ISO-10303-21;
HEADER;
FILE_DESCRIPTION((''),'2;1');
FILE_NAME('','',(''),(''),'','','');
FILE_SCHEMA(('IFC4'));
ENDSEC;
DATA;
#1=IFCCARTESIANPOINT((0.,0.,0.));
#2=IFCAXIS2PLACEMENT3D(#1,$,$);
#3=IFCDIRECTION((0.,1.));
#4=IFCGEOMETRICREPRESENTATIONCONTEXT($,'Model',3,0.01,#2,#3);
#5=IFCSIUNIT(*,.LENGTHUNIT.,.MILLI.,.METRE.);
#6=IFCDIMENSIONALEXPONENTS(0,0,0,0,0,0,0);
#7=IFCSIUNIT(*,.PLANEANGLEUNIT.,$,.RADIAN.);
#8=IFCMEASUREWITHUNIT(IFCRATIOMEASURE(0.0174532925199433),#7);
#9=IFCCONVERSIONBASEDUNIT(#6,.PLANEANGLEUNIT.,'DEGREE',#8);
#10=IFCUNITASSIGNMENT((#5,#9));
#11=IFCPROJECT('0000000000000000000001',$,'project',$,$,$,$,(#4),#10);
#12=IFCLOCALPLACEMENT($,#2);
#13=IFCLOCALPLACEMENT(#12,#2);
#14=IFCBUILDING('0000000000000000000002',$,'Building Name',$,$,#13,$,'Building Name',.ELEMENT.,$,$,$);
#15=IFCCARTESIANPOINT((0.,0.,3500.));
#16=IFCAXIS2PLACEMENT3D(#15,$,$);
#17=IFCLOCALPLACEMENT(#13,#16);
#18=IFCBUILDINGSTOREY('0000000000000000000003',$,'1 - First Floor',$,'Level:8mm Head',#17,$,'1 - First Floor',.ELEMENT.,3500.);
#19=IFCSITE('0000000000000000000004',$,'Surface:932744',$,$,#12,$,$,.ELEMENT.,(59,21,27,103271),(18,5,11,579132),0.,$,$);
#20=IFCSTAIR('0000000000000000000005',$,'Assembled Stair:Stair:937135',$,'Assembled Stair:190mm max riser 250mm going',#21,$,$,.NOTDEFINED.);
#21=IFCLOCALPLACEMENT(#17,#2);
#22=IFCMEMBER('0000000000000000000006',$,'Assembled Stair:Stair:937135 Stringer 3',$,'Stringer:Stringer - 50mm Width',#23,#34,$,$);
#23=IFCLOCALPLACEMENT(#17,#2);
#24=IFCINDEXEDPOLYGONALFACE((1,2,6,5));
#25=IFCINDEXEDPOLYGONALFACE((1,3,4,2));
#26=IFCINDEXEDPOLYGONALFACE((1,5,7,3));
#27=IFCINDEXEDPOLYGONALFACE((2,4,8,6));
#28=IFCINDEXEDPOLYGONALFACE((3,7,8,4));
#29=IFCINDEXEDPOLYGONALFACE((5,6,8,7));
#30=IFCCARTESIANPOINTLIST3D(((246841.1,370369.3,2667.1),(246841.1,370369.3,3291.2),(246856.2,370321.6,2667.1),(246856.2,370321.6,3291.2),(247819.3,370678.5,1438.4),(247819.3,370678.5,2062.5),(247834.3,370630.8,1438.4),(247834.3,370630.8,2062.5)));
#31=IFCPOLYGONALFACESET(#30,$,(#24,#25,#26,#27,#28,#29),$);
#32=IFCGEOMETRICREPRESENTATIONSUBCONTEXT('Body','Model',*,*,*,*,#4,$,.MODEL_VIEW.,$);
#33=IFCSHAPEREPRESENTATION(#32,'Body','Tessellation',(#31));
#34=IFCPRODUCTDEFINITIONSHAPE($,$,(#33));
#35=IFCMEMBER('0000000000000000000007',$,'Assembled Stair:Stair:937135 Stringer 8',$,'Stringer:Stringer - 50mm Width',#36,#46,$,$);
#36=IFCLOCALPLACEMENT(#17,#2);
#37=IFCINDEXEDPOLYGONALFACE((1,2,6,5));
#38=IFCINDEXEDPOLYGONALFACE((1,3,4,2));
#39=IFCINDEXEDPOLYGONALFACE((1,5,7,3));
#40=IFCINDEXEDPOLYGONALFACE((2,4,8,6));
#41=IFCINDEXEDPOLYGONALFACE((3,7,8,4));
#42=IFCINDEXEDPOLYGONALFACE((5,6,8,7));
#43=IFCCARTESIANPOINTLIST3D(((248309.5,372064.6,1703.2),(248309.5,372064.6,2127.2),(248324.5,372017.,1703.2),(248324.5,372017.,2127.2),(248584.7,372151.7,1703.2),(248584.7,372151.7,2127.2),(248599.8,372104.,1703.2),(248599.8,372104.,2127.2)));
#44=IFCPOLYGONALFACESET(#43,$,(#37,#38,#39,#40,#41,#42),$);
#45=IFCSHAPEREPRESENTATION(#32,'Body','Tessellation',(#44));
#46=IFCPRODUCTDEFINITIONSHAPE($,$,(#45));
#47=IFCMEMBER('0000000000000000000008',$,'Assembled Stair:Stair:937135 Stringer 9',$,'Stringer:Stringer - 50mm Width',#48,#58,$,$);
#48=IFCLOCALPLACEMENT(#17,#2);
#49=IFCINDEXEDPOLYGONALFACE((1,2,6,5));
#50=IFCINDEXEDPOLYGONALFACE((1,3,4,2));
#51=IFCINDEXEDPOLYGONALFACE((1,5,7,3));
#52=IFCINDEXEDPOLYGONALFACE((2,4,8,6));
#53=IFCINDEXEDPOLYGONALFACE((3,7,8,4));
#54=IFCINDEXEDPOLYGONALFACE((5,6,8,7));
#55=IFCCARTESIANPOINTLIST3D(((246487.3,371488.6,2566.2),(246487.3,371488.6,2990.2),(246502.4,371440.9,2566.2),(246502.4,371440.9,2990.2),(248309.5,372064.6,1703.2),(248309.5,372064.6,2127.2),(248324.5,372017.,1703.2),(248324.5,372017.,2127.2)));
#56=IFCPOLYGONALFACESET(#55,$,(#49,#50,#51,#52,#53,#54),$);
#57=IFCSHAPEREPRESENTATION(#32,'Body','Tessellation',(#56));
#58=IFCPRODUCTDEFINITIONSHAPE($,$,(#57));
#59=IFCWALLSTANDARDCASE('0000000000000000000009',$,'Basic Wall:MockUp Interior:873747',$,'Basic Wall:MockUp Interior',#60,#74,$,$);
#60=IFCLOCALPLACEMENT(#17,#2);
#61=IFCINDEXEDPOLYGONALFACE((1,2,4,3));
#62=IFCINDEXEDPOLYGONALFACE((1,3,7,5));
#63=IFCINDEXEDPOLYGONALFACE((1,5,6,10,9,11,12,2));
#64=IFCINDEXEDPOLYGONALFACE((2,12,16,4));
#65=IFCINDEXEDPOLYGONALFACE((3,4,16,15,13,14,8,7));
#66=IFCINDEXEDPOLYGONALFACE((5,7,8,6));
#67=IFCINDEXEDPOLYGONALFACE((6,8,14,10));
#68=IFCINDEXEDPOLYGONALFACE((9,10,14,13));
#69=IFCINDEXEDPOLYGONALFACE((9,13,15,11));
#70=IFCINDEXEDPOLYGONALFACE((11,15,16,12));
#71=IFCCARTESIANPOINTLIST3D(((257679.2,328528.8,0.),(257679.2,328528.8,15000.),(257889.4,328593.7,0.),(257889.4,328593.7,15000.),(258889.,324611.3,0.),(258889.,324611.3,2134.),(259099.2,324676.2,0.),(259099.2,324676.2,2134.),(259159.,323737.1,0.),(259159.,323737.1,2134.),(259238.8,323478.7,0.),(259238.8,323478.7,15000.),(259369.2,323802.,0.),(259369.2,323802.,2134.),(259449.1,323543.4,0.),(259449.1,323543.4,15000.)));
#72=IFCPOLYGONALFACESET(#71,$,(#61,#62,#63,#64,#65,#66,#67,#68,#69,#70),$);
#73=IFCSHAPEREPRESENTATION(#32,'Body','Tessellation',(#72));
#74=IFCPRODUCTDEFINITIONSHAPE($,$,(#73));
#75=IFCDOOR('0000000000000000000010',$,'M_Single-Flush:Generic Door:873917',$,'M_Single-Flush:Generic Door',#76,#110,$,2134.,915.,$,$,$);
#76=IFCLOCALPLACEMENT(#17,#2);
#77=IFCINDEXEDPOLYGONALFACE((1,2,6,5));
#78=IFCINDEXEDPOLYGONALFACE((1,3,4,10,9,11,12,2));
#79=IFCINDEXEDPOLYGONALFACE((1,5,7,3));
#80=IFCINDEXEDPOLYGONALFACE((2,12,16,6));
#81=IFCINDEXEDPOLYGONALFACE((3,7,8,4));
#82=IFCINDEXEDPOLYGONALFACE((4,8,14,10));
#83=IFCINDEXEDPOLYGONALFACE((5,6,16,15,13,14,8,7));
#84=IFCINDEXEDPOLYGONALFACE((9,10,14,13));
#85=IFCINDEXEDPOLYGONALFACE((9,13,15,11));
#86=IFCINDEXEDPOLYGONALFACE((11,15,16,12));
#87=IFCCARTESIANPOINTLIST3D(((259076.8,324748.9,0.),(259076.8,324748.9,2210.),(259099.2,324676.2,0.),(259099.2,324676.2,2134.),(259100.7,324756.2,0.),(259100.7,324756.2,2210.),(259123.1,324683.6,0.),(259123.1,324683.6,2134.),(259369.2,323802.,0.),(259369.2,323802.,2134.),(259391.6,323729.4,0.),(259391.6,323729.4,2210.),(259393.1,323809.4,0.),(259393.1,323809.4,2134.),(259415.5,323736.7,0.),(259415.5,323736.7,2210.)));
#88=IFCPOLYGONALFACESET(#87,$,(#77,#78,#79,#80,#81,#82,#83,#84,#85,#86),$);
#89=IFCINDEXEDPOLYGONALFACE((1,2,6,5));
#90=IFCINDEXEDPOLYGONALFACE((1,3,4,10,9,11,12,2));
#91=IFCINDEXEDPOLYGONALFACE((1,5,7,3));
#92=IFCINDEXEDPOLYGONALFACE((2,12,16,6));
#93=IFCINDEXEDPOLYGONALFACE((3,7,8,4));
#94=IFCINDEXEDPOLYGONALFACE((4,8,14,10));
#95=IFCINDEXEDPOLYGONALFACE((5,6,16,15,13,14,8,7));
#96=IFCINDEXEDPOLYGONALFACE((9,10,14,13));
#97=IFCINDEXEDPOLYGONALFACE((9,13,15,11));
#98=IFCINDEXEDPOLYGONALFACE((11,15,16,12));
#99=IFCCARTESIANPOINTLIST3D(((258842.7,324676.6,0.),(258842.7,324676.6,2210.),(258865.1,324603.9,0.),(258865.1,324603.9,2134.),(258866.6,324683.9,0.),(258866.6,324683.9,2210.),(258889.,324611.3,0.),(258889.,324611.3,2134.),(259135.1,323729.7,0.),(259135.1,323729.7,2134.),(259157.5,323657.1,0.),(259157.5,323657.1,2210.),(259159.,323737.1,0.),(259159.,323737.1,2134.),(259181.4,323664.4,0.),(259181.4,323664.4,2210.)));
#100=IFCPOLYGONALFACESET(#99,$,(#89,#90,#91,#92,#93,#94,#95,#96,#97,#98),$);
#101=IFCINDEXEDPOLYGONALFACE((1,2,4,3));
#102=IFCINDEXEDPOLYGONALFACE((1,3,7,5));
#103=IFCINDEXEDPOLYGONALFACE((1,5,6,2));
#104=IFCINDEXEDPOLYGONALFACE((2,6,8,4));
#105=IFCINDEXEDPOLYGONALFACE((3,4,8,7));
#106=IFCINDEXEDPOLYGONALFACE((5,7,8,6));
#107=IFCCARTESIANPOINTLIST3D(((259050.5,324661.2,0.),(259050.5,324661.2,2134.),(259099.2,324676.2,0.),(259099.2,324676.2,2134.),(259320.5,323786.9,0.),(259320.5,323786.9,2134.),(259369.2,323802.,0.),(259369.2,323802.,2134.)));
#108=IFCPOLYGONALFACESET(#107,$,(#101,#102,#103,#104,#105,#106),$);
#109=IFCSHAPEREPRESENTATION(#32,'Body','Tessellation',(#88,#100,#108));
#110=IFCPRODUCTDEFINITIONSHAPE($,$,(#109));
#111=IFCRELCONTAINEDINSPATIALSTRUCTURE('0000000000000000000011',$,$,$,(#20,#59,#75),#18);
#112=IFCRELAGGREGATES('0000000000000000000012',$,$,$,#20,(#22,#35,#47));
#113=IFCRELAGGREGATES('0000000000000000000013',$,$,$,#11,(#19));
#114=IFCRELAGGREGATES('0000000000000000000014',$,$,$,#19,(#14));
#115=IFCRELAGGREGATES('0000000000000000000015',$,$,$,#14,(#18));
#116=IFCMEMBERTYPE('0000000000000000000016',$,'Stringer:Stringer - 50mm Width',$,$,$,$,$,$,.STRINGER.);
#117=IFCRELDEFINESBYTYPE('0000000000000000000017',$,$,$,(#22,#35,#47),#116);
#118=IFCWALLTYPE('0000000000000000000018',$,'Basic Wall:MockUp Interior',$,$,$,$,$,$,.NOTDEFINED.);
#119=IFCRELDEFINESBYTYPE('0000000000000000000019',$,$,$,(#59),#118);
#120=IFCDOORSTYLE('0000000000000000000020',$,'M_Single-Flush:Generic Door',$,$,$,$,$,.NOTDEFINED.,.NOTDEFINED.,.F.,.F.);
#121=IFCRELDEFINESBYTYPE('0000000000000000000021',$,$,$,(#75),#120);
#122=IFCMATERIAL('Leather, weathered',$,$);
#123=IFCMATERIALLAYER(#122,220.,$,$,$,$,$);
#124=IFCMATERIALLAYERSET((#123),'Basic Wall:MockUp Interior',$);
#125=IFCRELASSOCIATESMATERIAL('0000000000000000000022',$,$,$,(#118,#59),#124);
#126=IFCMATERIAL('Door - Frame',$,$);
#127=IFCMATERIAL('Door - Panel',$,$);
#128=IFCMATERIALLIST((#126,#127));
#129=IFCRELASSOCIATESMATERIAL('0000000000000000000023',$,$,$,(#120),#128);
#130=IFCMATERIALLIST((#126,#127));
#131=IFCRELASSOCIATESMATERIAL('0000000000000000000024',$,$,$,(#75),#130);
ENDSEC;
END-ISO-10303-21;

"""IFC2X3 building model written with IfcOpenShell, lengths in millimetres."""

from ifc_helpers import new_model, entity, si_unit, converted_unit, direction, frame, frame_2d, origin, place, context, subcontext, project, spatial, polyline, rectangle, outline, extrude, source, transform, mapped, material, material_list, layer, layer_set, layer_usage, type_object, type_shapes, element, fill, aggregate, save


model = new_model("IFC2X3")

# Units and contexts
model_context = context("Model", 3, precision=0.01, world=origin(), true_north=direction((0.0, 1.0)))
body_context = subcontext(model_context, "Body", "Model", "MODEL_VIEW")
ifc_project = project(units=[si_unit("LENGTHUNIT", "METRE", prefix="MILLI"), converted_unit("PLANEANGLEUNIT", "DEGREE", entity("IfcRatioMeasure", 0.0174532925199433), si_unit("PLANEANGLEUNIT", "RADIAN"), dimensions=[0, 0, 0, 0, 0, 0, 0])], contexts=[model_context])

# Site, building, storey
site_placement = place(None, origin())
site = spatial("IfcSite", under=ifc_project, at=site_placement, Name="Surface:932744", CompositionType="ELEMENT", RefLatitude=(59, 21, 27, 103271), RefLongitude=(18, 5, 11, 579132), RefElevation=0.0)
building_placement = place(site_placement, origin())
building = spatial("IfcBuilding", under=site, at=building_placement, Name="Building Name", LongName="Building Name", CompositionType="ELEMENT")
storey_placement = place(building_placement, frame((0.0, 0.0, 3500.0)))
storey = spatial("IfcBuildingStorey", under=building, at=storey_placement, Name="1 - First Floor", ObjectType="Level:8mm Head", LongName="1 - First Floor", CompositionType="ELEMENT", Elevation=3500.0)

# Stair, members
stair_placement = place(storey_placement, origin())
stair = element("IfcStair", 1, at=stair_placement, inside=storey, Name="Assembled Stair:Stair:937135", ObjectType="Assembled Stair:190mm max riser 250mm going", ShapeType="NOTDEFINED")
member_type = type_object("IfcMemberType", Name="Stringer:Stringer - 50mm Width", PredefinedType="STRINGER")
member_1_placement = place(stair_placement, origin())
member_1 = element("IfcMember", 2, at=member_1_placement, type_object=member_type, Name="Assembled Stair:Stair:937135 Stringer 3", ObjectType="Stringer:Stringer - 50mm Width", context=body_context, shape_type="SweptSolid", body=[
    extrude(outline(polyline([(-1039.9, -200.0), (560.8, -200.0), (1039.9, 200.0), (-560.8, 200.0), (-1039.9, -200.0)])), frame((247345.3, 370476.2, 2364.8), z_axis=(-0.301424, 0.95349, 0.0), x_axis=(-0.611082, -0.193179, 0.767633)), (0.0, 0.0, 1.0), 50.0),
])
member_2_placement = place(stair_placement, origin())
member_2 = element("IfcMember", 3, at=member_2_placement, type_object=member_type, Name="Assembled Stair:Stair:937135 Stringer 8", ObjectType="Stringer:Stringer - 50mm Width", context=body_context, shape_type="SweptSolid", body=[
    extrude(rectangle(XDim=288.7, YDim=50.0, at=frame_2d((0.0, 0.0), x_axis=(1.0, 0.0))), frame((248454.6, 372084.3, 1703.2), z_axis=(0.0, 0.0, 1.0), x_axis=(-0.95349, -0.301424, 0.0)), (0.0, 0.0, 1.0), 424.0),
])
member_3_placement = place(stair_placement, origin())
member_3 = element("IfcMember", 4, at=member_3_placement, type_object=member_type, Name="Assembled Stair:Stair:937135 Stringer 9", ObjectType="Stringer:Stringer - 50mm Width", context=body_context, shape_type="SweptSolid", body=[
    extrude(outline(polyline([(-1135.7, -193.2), (961.2, -193.2), (1135.7, 193.2), (-961.2, 193.2), (-1135.7, -193.2)])), frame((247413.5, 371728.9, 2346.7), z_axis=(-0.301424, 0.95349, 0.0), x_axis=(-0.868997, -0.274713, 0.411555)), (0.0, 0.0, 1.0), 50.0),
])

# Wall, opening, door
ifc_material_1 = material(Name="Leather, weathered")
ifc_layer_1 = layer(ifc_material_1, 220.0)
ifc_layer_set_1 = layer_set([ifc_layer_1], Name="Basic Wall:MockUp Interior")
ifc_layer_usage_1 = layer_usage(ifc_layer_set_1, "AXIS2", "NEGATIVE", 110.0)
wall_type_1 = type_object("IfcWallType", Name="Basic Wall:MockUp Interior", PredefinedType="NOTDEFINED", material=ifc_layer_set_1)
wall_1_placement = place(storey_placement, frame((259344.0, 323510.9, 0.0), z_axis=(0.0, 0.0, 1.0), x_axis=(-0.29508, 0.955473, 0.0)))
wall_1 = element("IfcWallStandardCase", 5, at=wall_1_placement, inside=storey, type_object=wall_type_1, material=ifc_layer_usage_1, Name="Basic Wall:MockUp Interior:873747", ObjectType="Basic Wall:MockUp Interior", context=body_context, shape_type="SweptSolid", body=[
    extrude(outline(polyline([(0.0, -110.0), (5285.7, -110.0), (5285.7, 110.0), (0.3, 110.0), (0.0, -110.0)])), origin(), (0.0, 0.0, 1.0), 15000.0),
])
opening_1_placement = place(wall_1_placement, frame((1185.7, 110.0, 0.0)))
opening_1 = element("IfcOpeningElement", 6, at=opening_1_placement, cuts=wall_1, ObjectType="Opening", context=body_context, shape_type="SweptSolid", body=[
    extrude(rectangle(XDim=915.0, YDim=2134.0, at=frame_2d((1067.0, 457.5), x_axis=(0.0, 1.0))), frame((0.0, 0.0, 0.0), z_axis=(0.0, -1.0, 0.0), x_axis=(0.0, 0.0, 1.0)), (0.0, 0.0, 1.0), 220.0),
])
ifc_material_2 = material(Name="Door - Frame")
ifc_material_3 = material(Name="Door - Panel")
ifc_material_list_1 = material_list([ifc_material_2, ifc_material_3])
ifc_material_list_2 = material_list([ifc_material_2, ifc_material_3])
door_style = type_object("IfcDoorStyle", Name="M_Single-Flush:Generic Door", ConstructionType="NOTDEFINED", OperationType="NOTDEFINED", ParameterTakesPrecedence=False, Sizeable=False, material=ifc_material_list_2)
shared_shape_1 = source(origin(), body_context, "Body", "SweptSolid", [
    extrude(outline(polyline([(-533.5, -1124.0), (533.5, -1124.0), (533.5, 1086.0), (457.5, 1086.0), (457.5, -1048.0), (-457.5, -1048.0), (-457.5, 1086.0), (-533.5, 1086.0), (-533.5, -1124.0)])), frame((457.5, 220.0, 1086.0), z_axis=(0.0, 1.0, 0.0), x_axis=(1.0, 0.0, 0.0)), (0.0, 0.0, 1.0), 25.0),
    extrude(outline(polyline([(-1124.0, -533.5), (1086.0, -533.5), (1086.0, -457.5), (-1048.0, -457.5), (-1048.0, 457.5), (1086.0, 457.5), (1086.0, 533.5), (-1124.0, 533.5), (-1124.0, -533.5)])), frame((457.5, -25.0, 1086.0), z_axis=(0.0, 1.0, 0.0), x_axis=(0.0, 0.0, -1.0)), (0.0, 0.0, 1.0), 25.0),
    extrude(rectangle(XDim=51.0, YDim=915.0, at=frame_2d((0.0, 0.0), x_axis=(1.0, 0.0))), frame((457.5, 194.5, 0.0), z_axis=(0.0, 0.0, 1.0), x_axis=(0.0, 1.0, 0.0)), (0.0, 0.0, 1.0), 2134.0),
])
type_shapes(door_style, [shared_shape_1])
door_placement = place(opening_1_placement, frame((0.0, 0.0, 0.0), z_axis=(0.0, 0.0, 1.0), x_axis=(-1.0, 0.0, 0.0)))
door = element("IfcDoor", 7, at=door_placement, inside=storey, type_object=door_style, material=ifc_material_list_1, Name="M_Single-Flush:Generic Door:873917", ObjectType="M_Single-Flush:Generic Door", OverallHeight=2134.0, OverallWidth=915.0, context=body_context, shape_type="MappedRepresentation", body=[
    mapped(shared_shape_1, transform((0.0, 0.0, 0.0), scale=1.0)),
])
fill(opening_1, door)

aggregate(stair, [member_1, member_2, member_3])

save(model, "model.ifc")
